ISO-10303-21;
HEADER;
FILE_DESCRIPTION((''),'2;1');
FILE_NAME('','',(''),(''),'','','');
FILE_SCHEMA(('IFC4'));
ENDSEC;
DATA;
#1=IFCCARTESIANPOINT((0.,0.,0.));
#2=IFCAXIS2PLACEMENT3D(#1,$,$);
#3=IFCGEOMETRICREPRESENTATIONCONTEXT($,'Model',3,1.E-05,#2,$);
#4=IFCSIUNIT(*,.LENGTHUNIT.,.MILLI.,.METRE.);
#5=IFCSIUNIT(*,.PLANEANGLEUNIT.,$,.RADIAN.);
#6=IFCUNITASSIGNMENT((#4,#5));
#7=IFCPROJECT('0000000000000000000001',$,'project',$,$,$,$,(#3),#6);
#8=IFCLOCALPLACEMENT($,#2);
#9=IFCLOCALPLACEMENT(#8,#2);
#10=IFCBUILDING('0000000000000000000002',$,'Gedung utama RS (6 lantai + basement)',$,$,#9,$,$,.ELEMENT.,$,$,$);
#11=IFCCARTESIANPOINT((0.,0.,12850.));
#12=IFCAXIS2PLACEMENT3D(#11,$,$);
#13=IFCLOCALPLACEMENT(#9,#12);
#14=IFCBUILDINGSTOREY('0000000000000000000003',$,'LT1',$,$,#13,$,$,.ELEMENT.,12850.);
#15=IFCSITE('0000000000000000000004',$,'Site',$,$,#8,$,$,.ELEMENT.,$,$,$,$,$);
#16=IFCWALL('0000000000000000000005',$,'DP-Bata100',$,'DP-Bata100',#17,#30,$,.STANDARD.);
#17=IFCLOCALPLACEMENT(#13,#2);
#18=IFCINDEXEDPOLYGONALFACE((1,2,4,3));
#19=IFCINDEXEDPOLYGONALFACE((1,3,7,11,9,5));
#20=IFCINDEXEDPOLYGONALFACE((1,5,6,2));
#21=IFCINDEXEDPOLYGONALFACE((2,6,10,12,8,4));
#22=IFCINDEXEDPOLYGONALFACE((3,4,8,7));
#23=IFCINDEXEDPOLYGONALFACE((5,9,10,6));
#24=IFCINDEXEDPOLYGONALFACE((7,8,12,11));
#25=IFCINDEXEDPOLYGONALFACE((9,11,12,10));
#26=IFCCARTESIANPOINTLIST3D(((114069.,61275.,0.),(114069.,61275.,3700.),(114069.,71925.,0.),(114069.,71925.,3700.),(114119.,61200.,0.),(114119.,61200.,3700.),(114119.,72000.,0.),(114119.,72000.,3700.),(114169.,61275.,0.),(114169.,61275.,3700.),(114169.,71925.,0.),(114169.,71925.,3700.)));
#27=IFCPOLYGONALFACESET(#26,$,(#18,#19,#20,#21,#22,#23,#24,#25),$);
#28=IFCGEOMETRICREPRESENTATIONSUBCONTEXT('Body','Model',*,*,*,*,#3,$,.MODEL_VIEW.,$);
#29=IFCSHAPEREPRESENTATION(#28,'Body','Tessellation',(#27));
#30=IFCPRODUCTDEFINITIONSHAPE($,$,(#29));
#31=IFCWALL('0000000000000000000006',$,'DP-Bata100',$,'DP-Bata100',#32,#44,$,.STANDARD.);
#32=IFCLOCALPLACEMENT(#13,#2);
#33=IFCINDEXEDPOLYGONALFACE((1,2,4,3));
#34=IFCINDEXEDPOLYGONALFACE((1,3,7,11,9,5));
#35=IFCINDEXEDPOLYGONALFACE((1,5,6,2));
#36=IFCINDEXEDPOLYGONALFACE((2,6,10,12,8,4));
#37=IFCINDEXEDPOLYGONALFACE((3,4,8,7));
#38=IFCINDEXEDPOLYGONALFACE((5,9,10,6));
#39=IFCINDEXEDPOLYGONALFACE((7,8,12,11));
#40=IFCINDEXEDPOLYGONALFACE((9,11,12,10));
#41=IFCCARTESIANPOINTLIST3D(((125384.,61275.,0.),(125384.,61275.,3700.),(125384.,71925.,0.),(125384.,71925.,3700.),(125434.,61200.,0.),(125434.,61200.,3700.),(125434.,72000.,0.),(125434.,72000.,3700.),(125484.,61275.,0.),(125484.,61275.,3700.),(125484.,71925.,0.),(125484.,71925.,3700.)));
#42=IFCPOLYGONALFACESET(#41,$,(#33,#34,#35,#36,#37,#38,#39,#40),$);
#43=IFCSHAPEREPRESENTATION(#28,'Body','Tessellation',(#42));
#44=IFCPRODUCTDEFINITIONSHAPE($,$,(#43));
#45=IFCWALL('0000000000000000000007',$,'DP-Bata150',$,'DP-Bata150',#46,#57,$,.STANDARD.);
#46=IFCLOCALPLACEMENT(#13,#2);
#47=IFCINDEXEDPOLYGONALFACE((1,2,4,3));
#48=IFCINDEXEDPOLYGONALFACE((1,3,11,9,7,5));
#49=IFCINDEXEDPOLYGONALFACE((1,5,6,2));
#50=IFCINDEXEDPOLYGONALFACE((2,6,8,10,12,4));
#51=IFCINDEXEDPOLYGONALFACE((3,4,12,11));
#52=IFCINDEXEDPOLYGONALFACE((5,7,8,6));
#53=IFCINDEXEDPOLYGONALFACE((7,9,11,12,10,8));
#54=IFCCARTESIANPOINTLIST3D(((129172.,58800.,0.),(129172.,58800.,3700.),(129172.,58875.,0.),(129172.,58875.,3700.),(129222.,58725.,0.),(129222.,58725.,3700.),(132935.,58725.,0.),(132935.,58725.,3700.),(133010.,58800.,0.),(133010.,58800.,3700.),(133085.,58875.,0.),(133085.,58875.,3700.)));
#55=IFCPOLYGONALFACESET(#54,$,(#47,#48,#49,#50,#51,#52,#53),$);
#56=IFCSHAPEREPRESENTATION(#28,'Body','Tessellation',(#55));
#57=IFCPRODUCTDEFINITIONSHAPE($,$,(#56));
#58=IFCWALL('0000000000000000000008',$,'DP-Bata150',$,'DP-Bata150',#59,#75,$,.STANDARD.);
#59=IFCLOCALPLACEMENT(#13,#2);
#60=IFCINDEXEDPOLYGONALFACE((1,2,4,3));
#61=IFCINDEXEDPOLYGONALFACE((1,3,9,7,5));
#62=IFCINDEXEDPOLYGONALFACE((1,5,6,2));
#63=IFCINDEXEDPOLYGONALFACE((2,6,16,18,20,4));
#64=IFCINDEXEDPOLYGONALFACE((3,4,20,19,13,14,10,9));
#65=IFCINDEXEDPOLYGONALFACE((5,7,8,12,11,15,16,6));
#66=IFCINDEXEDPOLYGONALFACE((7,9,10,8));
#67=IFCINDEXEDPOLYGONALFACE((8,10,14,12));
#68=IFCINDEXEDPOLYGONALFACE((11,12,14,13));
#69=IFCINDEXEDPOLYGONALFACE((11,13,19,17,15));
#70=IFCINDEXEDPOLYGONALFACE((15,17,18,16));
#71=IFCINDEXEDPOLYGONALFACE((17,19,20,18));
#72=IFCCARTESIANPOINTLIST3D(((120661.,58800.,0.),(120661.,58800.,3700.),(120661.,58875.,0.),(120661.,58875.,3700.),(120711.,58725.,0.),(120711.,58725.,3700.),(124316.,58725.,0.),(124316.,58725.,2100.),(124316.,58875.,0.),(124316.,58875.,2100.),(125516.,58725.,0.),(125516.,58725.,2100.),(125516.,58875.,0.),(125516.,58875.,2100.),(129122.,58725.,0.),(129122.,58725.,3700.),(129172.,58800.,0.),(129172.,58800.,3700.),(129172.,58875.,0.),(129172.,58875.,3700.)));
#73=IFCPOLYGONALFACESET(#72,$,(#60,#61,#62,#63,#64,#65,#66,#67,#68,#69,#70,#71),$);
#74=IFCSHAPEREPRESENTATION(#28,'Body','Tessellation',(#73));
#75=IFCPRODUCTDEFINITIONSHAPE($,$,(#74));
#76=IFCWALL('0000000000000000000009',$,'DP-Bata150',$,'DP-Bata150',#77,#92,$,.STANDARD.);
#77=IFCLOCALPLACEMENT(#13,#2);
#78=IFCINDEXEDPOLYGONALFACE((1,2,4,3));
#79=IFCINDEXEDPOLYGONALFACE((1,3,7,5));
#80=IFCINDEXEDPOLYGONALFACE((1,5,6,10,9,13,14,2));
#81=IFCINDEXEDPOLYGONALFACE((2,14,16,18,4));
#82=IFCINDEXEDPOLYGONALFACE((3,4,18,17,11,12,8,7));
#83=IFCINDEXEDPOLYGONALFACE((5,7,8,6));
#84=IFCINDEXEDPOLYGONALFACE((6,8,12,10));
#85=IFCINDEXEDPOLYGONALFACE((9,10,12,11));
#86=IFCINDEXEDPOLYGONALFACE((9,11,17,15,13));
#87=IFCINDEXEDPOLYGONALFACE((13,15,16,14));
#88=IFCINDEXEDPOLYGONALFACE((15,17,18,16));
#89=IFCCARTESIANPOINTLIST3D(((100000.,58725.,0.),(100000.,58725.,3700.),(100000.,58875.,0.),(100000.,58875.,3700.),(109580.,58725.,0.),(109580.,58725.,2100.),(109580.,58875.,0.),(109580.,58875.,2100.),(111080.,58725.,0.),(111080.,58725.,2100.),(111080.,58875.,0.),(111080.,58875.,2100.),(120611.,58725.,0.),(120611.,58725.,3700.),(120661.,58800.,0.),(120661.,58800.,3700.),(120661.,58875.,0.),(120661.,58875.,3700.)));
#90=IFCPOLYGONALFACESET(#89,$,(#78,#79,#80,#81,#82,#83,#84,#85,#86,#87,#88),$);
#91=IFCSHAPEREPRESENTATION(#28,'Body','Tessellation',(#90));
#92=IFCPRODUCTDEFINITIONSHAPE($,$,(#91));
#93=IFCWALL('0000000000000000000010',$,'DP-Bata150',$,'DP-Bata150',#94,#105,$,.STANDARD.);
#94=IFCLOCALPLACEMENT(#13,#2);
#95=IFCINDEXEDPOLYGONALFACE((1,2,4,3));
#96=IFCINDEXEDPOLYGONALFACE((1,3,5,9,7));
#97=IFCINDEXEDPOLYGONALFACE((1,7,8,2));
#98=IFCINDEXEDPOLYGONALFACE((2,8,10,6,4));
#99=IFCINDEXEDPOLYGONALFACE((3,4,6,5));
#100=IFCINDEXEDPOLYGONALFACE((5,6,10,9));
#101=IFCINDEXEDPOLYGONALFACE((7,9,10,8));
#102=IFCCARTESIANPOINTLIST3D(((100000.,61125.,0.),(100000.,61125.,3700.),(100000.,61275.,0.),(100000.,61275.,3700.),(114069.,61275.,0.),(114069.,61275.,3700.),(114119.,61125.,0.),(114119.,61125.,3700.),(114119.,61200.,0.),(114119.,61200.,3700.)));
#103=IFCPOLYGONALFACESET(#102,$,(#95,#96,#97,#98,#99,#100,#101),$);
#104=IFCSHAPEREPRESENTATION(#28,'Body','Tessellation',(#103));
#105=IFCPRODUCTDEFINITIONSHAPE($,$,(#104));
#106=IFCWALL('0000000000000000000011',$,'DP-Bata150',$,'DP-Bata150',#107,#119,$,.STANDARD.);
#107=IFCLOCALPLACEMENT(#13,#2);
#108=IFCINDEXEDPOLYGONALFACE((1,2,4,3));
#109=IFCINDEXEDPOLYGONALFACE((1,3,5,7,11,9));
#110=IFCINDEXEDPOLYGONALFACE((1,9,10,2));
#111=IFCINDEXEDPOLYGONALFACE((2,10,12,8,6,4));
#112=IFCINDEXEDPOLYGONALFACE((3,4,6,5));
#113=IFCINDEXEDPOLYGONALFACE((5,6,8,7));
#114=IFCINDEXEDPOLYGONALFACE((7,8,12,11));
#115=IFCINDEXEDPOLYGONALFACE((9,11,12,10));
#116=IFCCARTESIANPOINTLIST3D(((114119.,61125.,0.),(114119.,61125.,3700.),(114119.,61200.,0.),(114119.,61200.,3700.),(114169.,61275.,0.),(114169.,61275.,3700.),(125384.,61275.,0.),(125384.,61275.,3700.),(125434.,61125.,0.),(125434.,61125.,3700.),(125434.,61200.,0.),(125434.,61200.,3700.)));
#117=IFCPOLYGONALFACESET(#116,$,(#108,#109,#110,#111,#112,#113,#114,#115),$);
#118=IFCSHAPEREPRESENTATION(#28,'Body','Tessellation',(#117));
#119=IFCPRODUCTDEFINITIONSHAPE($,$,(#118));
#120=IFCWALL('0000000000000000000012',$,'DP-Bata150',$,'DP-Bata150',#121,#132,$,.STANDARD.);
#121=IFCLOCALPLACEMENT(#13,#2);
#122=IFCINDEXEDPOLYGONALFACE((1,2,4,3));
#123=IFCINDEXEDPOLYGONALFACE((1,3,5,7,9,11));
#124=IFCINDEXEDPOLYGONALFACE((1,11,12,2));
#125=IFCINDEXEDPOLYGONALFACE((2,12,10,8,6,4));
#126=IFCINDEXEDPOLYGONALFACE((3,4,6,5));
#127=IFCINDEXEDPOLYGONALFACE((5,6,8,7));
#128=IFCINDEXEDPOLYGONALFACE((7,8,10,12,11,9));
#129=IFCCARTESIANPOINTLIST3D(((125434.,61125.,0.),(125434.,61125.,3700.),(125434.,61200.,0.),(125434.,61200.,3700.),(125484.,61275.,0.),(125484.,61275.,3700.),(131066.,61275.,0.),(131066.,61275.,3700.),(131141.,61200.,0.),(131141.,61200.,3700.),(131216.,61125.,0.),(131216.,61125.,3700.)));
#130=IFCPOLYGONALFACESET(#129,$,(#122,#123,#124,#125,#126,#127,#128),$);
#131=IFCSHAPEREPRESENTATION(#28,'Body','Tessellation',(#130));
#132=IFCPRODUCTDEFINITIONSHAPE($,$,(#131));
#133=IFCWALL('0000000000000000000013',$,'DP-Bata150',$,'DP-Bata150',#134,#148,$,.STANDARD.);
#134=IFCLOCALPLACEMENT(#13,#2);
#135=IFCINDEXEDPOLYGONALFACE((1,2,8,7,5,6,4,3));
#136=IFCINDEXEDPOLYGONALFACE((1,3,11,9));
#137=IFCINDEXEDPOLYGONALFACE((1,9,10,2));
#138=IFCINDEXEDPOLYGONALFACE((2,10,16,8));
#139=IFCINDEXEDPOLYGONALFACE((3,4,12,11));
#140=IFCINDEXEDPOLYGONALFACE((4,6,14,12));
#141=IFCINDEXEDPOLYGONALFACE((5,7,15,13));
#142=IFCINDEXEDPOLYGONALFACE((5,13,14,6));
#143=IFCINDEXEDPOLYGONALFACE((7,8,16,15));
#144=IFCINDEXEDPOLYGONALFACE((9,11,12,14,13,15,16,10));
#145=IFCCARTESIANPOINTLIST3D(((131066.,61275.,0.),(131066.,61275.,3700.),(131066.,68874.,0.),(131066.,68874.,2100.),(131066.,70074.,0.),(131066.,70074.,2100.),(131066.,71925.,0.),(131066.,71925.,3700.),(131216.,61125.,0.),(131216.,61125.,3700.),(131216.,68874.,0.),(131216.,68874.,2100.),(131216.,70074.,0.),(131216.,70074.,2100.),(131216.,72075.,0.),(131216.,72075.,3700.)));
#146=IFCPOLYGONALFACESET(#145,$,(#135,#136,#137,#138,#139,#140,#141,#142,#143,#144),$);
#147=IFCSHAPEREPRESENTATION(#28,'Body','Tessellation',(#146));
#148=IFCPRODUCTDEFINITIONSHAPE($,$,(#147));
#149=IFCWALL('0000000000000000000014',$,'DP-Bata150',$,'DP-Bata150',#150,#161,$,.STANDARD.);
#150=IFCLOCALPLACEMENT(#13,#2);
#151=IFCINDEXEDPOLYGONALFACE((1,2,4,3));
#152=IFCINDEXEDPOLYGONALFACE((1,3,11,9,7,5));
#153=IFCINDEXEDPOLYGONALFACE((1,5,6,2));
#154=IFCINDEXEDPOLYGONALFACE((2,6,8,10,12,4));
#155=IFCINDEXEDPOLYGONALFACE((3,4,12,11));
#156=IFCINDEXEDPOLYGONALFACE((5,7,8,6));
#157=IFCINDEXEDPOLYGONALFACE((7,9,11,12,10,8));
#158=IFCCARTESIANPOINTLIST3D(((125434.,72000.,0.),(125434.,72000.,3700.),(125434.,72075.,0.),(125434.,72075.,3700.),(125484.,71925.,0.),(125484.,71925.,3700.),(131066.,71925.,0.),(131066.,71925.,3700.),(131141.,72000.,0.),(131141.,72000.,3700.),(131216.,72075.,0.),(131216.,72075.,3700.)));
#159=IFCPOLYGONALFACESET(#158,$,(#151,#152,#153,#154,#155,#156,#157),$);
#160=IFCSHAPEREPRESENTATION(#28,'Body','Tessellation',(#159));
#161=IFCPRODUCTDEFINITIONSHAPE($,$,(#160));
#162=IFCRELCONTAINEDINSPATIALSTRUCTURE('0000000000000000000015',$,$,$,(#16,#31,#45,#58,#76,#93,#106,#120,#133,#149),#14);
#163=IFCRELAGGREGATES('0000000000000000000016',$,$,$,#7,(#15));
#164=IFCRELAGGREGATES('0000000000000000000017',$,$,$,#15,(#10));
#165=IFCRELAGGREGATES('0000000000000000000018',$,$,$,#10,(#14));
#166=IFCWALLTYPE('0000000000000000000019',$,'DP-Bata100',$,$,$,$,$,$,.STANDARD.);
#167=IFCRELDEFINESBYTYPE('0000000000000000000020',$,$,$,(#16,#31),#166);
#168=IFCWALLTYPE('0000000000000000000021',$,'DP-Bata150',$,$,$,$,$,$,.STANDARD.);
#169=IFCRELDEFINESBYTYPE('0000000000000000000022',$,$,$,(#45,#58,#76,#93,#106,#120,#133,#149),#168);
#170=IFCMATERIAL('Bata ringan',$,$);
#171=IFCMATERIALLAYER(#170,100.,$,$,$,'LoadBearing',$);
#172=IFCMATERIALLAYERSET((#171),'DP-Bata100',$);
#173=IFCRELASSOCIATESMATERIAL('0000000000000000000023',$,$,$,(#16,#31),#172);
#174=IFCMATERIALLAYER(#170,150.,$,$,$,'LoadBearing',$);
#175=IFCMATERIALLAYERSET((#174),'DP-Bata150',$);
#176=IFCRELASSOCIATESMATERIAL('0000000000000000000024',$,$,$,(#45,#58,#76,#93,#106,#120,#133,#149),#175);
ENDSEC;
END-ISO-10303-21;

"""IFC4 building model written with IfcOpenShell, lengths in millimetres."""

from ifc_helpers import new_model, si_unit, frame, frame_2d, origin, place, context, subcontext, project, spatial, polyline, rectangle, outline, extrude, material, layer, layer_set, layer_usage, type_object, element, save


model = new_model("IFC4")

# Units and contexts
model_context = context("Model", 3, precision=1e-05, world=origin())
body_context = subcontext(model_context, "Body", "Model", "MODEL_VIEW")
ifc_project = project(units=[si_unit("LENGTHUNIT", "METRE", prefix="MILLI"), si_unit("PLANEANGLEUNIT", "RADIAN")], contexts=[model_context])

# Site, building, storey
site_placement = place(None, origin())
site = spatial("IfcSite", under=ifc_project, at=site_placement, Name="Site", CompositionType="ELEMENT")
building_placement = place(site_placement, origin())
building = spatial("IfcBuilding", under=site, at=building_placement, Name="Gedung utama RS (6 lantai + basement)", CompositionType="ELEMENT")
storey_placement = place(building_placement, frame((0.0, 0.0, 12850.0)))
storey = spatial("IfcBuildingStorey", under=building, at=storey_placement, Name="LT1", CompositionType="ELEMENT", Elevation=12850.0)

# Walls
ifc_material_1 = material(Name="Bata ringan")
ifc_layer_1 = layer(ifc_material_1, 100.0, Category="LoadBearing")
ifc_layer_set_1 = layer_set([ifc_layer_1], Name="DP-Bata100")
ifc_layer_usage_1 = layer_usage(ifc_layer_set_1, "AXIS2", "NEGATIVE", 50.0)
wall_type_1 = type_object("IfcWallType", Name="DP-Bata100", PredefinedType="STANDARD")
for number, where, z_axis, x_axis, name in (
    (1, (114119.0, 61200.0, 0.0), (0.0, 0.0, 1.0), (0.0, 1.0, 0.0), "DP-Bata100"),
    (2, (125434.0, 61200.0, 0.0), (0.0, 0.0, 1.0), (0.0, 1.0, 0.0), "DP-Bata100"),
):
    element("IfcWall", number, at=place(storey_placement, frame(where, z_axis=z_axis, x_axis=x_axis)), inside=storey, type_object=wall_type_1, material=ifc_layer_usage_1, Name=name, ObjectType="DP-Bata100", PredefinedType="STANDARD", context=body_context, shape_type="SweptSolid", body=[
        extrude(outline(polyline([(75.0, -50.0), (0.0, 0.0), (75.0, 50.0), (10725.0, 50.0), (10800.0, 0.0), (10725.0, -50.0), (75.0, -50.0)])), origin(), (0.0, 0.0, 1.0), 3700.0),
    ])
ifc_layer_2 = layer(ifc_material_1, 150.0, Category="LoadBearing")
ifc_layer_set_2 = layer_set([ifc_layer_2], Name="DP-Bata150")
ifc_layer_usage_2 = layer_usage(ifc_layer_set_2, "AXIS2", "NEGATIVE", 75.0)
wall_type_2 = type_object("IfcWallType", Name="DP-Bata150", PredefinedType="STANDARD")
wall_1_placement = place(storey_placement, frame((133010.0, 58800.0, 0.0), z_axis=(0.0, 0.0, 1.0), x_axis=(-1.0, 0.0, 0.0)))
element("IfcWall", 3, at=wall_1_placement, inside=storey, type_object=wall_type_2, material=ifc_layer_usage_2, Name="DP-Bata150", ObjectType="DP-Bata150", PredefinedType="STANDARD", context=body_context, shape_type="SweptSolid", body=[
    extrude(outline(polyline([(-75.0, -75.0), (0.0, 0.0), (75.0, 75.0), (3788.0, 75.0), (3838.0, 0.0), (3838.0, -75.0), (-75.0, -75.0)])), origin(), (0.0, 0.0, 1.0), 3700.0),
])

# Walls, openings
wall_2_placement = place(storey_placement, frame((129172.0, 58800.0, 0.0), z_axis=(0.0, 0.0, 1.0), x_axis=(-1.0, 0.0, 0.0)))
wall_2 = element("IfcWall", 4, at=wall_2_placement, inside=storey, type_object=wall_type_2, material=ifc_layer_usage_2, Name="DP-Bata150", ObjectType="DP-Bata150", PredefinedType="STANDARD", context=body_context, shape_type="SweptSolid", body=[
    extrude(outline(polyline([(0.0, -75.0), (0.0, 0.0), (50.0, 75.0), (8461.0, 75.0), (8511.0, 0.0), (8511.0, -75.0), (0.0, -75.0)])), origin(), (0.0, 0.0, 1.0), 3700.0),
])
opening_1_placement = place(wall_2_placement, frame((3656.0, 0.0, 0.0), z_axis=(0.0, 0.0, 1.0), x_axis=(1.0, 0.0, 0.0)))
element("IfcOpeningElement", 5, at=opening_1_placement, cuts=wall_2, PredefinedType="OPENING", context=body_context, shape_type="SweptSolid", body=[
    extrude(rectangle(XDim=1200.0, YDim=170.0, at=frame_2d((600.0, 0.0))), origin(), (0.0, 0.0, 1.0), 2100.0),
])
wall_3_placement = place(storey_placement, frame((120661.0, 58800.0, 0.0), z_axis=(0.0, 0.0, 1.0), x_axis=(-1.0, 0.0, 0.0)))
wall_3 = element("IfcWall", 6, at=wall_3_placement, inside=storey, type_object=wall_type_2, material=ifc_layer_usage_2, Name="DP-Bata150", ObjectType="DP-Bata150", PredefinedType="STANDARD", context=body_context, shape_type="SweptSolid", body=[
    extrude(outline(polyline([(0.0, -75.0), (0.0, 0.0), (50.0, 75.0), (20661.0, 75.0), (20661.0, -75.0), (0.0, -75.0)])), origin(), (0.0, 0.0, 1.0), 3700.0),
])
opening_2_placement = place(wall_3_placement, frame((9581.0, 0.0, 0.0), z_axis=(0.0, 0.0, 1.0), x_axis=(1.0, 0.0, 0.0)))
element("IfcOpeningElement", 7, at=opening_2_placement, cuts=wall_3, PredefinedType="OPENING", context=body_context, shape_type="SweptSolid", body=[
    extrude(rectangle(XDim=1500.0, YDim=170.0, at=frame_2d((750.0, 0.0))), origin(), (0.0, 0.0, 1.0), 2100.0),
])

# Walls
wall_4_placement = place(storey_placement, frame((100000.0, 61200.0, 0.0), z_axis=(0.0, 0.0, 1.0), x_axis=(1.0, 0.0, 0.0)))
element("IfcWall", 8, at=wall_4_placement, inside=storey, type_object=wall_type_2, material=ifc_layer_usage_2, Name="DP-Bata150", ObjectType="DP-Bata150", PredefinedType="STANDARD", context=body_context, shape_type="SweptSolid", body=[
    extrude(outline(polyline([(0.0, -75.0), (0.0, 75.0), (14069.0, 75.0), (14119.0, 0.0), (14119.0, -75.0), (0.0, -75.0)])), origin(), (0.0, 0.0, 1.0), 3700.0),
])
wall_5_placement = place(storey_placement, frame((114119.0, 61200.0, 0.0), z_axis=(0.0, 0.0, 1.0), x_axis=(1.0, 0.0, 0.0)))
element("IfcWall", 9, at=wall_5_placement, inside=storey, type_object=wall_type_2, material=ifc_layer_usage_2, Name="DP-Bata150", ObjectType="DP-Bata150", PredefinedType="STANDARD", context=body_context, shape_type="SweptSolid", body=[
    extrude(outline(polyline([(0.0, -75.0), (0.0, 0.0), (50.0, 75.0), (11265.0, 75.0), (11315.0, 0.0), (11315.0, -75.0), (0.0, -75.0)])), origin(), (0.0, 0.0, 1.0), 3700.0),
])
wall_6_placement = place(storey_placement, frame((125434.0, 61200.0, 0.0), z_axis=(0.0, 0.0, 1.0), x_axis=(1.0, 0.0, 0.0)))
element("IfcWall", 10, at=wall_6_placement, inside=storey, type_object=wall_type_2, material=ifc_layer_usage_2, Name="DP-Bata150", ObjectType="DP-Bata150", PredefinedType="STANDARD", context=body_context, shape_type="SweptSolid", body=[
    extrude(outline(polyline([(0.0, -75.0), (0.0, 0.0), (50.0, 75.0), (5632.0, 75.0), (5707.0, 0.0), (5782.0, -75.0), (0.0, -75.0)])), origin(), (0.0, 0.0, 1.0), 3700.0),
])

# Wall, opening
wall_7_placement = place(storey_placement, frame((131141.0, 61200.0, 0.0), z_axis=(0.0, 0.0, 1.0), x_axis=(0.0, 1.0, 0.0)))
wall_7 = element("IfcWall", 11, at=wall_7_placement, inside=storey, type_object=wall_type_2, material=ifc_layer_usage_2, Name="DP-Bata150", ObjectType="DP-Bata150", PredefinedType="STANDARD", context=body_context, shape_type="SweptSolid", body=[
    extrude(outline(polyline([(-75.0, -75.0), (0.0, 0.0), (75.0, 75.0), (10725.0, 75.0), (10800.0, 0.0), (10875.0, -75.0), (-75.0, -75.0)])), origin(), (0.0, 0.0, 1.0), 3700.0),
])
opening_3_placement = place(wall_7_placement, frame((7674.0, 0.0, 0.0), z_axis=(0.0, 0.0, 1.0), x_axis=(1.0, 0.0, 0.0)))
element("IfcOpeningElement", 12, at=opening_3_placement, cuts=wall_7, PredefinedType="OPENING", context=body_context, shape_type="SweptSolid", body=[
    extrude(rectangle(XDim=1200.0, YDim=170.0, at=frame_2d((600.0, 0.0))), origin(), (0.0, 0.0, 1.0), 2100.0),
])

# Wall
wall_8_placement = place(storey_placement, frame((131141.0, 72000.0, 0.0), z_axis=(0.0, 0.0, 1.0), x_axis=(-1.0, 0.0, 0.0)))
element("IfcWall", 13, at=wall_8_placement, inside=storey, type_object=wall_type_2, material=ifc_layer_usage_2, Name="DP-Bata150", ObjectType="DP-Bata150", PredefinedType="STANDARD", context=body_context, shape_type="SweptSolid", body=[
    extrude(outline(polyline([(-75.0, -75.0), (0.0, 0.0), (75.0, 75.0), (5657.0, 75.0), (5707.0, 0.0), (5707.0, -75.0), (-75.0, -75.0)])), origin(), (0.0, 0.0, 1.0), 3700.0),
])

save(model, "model.ifc")
